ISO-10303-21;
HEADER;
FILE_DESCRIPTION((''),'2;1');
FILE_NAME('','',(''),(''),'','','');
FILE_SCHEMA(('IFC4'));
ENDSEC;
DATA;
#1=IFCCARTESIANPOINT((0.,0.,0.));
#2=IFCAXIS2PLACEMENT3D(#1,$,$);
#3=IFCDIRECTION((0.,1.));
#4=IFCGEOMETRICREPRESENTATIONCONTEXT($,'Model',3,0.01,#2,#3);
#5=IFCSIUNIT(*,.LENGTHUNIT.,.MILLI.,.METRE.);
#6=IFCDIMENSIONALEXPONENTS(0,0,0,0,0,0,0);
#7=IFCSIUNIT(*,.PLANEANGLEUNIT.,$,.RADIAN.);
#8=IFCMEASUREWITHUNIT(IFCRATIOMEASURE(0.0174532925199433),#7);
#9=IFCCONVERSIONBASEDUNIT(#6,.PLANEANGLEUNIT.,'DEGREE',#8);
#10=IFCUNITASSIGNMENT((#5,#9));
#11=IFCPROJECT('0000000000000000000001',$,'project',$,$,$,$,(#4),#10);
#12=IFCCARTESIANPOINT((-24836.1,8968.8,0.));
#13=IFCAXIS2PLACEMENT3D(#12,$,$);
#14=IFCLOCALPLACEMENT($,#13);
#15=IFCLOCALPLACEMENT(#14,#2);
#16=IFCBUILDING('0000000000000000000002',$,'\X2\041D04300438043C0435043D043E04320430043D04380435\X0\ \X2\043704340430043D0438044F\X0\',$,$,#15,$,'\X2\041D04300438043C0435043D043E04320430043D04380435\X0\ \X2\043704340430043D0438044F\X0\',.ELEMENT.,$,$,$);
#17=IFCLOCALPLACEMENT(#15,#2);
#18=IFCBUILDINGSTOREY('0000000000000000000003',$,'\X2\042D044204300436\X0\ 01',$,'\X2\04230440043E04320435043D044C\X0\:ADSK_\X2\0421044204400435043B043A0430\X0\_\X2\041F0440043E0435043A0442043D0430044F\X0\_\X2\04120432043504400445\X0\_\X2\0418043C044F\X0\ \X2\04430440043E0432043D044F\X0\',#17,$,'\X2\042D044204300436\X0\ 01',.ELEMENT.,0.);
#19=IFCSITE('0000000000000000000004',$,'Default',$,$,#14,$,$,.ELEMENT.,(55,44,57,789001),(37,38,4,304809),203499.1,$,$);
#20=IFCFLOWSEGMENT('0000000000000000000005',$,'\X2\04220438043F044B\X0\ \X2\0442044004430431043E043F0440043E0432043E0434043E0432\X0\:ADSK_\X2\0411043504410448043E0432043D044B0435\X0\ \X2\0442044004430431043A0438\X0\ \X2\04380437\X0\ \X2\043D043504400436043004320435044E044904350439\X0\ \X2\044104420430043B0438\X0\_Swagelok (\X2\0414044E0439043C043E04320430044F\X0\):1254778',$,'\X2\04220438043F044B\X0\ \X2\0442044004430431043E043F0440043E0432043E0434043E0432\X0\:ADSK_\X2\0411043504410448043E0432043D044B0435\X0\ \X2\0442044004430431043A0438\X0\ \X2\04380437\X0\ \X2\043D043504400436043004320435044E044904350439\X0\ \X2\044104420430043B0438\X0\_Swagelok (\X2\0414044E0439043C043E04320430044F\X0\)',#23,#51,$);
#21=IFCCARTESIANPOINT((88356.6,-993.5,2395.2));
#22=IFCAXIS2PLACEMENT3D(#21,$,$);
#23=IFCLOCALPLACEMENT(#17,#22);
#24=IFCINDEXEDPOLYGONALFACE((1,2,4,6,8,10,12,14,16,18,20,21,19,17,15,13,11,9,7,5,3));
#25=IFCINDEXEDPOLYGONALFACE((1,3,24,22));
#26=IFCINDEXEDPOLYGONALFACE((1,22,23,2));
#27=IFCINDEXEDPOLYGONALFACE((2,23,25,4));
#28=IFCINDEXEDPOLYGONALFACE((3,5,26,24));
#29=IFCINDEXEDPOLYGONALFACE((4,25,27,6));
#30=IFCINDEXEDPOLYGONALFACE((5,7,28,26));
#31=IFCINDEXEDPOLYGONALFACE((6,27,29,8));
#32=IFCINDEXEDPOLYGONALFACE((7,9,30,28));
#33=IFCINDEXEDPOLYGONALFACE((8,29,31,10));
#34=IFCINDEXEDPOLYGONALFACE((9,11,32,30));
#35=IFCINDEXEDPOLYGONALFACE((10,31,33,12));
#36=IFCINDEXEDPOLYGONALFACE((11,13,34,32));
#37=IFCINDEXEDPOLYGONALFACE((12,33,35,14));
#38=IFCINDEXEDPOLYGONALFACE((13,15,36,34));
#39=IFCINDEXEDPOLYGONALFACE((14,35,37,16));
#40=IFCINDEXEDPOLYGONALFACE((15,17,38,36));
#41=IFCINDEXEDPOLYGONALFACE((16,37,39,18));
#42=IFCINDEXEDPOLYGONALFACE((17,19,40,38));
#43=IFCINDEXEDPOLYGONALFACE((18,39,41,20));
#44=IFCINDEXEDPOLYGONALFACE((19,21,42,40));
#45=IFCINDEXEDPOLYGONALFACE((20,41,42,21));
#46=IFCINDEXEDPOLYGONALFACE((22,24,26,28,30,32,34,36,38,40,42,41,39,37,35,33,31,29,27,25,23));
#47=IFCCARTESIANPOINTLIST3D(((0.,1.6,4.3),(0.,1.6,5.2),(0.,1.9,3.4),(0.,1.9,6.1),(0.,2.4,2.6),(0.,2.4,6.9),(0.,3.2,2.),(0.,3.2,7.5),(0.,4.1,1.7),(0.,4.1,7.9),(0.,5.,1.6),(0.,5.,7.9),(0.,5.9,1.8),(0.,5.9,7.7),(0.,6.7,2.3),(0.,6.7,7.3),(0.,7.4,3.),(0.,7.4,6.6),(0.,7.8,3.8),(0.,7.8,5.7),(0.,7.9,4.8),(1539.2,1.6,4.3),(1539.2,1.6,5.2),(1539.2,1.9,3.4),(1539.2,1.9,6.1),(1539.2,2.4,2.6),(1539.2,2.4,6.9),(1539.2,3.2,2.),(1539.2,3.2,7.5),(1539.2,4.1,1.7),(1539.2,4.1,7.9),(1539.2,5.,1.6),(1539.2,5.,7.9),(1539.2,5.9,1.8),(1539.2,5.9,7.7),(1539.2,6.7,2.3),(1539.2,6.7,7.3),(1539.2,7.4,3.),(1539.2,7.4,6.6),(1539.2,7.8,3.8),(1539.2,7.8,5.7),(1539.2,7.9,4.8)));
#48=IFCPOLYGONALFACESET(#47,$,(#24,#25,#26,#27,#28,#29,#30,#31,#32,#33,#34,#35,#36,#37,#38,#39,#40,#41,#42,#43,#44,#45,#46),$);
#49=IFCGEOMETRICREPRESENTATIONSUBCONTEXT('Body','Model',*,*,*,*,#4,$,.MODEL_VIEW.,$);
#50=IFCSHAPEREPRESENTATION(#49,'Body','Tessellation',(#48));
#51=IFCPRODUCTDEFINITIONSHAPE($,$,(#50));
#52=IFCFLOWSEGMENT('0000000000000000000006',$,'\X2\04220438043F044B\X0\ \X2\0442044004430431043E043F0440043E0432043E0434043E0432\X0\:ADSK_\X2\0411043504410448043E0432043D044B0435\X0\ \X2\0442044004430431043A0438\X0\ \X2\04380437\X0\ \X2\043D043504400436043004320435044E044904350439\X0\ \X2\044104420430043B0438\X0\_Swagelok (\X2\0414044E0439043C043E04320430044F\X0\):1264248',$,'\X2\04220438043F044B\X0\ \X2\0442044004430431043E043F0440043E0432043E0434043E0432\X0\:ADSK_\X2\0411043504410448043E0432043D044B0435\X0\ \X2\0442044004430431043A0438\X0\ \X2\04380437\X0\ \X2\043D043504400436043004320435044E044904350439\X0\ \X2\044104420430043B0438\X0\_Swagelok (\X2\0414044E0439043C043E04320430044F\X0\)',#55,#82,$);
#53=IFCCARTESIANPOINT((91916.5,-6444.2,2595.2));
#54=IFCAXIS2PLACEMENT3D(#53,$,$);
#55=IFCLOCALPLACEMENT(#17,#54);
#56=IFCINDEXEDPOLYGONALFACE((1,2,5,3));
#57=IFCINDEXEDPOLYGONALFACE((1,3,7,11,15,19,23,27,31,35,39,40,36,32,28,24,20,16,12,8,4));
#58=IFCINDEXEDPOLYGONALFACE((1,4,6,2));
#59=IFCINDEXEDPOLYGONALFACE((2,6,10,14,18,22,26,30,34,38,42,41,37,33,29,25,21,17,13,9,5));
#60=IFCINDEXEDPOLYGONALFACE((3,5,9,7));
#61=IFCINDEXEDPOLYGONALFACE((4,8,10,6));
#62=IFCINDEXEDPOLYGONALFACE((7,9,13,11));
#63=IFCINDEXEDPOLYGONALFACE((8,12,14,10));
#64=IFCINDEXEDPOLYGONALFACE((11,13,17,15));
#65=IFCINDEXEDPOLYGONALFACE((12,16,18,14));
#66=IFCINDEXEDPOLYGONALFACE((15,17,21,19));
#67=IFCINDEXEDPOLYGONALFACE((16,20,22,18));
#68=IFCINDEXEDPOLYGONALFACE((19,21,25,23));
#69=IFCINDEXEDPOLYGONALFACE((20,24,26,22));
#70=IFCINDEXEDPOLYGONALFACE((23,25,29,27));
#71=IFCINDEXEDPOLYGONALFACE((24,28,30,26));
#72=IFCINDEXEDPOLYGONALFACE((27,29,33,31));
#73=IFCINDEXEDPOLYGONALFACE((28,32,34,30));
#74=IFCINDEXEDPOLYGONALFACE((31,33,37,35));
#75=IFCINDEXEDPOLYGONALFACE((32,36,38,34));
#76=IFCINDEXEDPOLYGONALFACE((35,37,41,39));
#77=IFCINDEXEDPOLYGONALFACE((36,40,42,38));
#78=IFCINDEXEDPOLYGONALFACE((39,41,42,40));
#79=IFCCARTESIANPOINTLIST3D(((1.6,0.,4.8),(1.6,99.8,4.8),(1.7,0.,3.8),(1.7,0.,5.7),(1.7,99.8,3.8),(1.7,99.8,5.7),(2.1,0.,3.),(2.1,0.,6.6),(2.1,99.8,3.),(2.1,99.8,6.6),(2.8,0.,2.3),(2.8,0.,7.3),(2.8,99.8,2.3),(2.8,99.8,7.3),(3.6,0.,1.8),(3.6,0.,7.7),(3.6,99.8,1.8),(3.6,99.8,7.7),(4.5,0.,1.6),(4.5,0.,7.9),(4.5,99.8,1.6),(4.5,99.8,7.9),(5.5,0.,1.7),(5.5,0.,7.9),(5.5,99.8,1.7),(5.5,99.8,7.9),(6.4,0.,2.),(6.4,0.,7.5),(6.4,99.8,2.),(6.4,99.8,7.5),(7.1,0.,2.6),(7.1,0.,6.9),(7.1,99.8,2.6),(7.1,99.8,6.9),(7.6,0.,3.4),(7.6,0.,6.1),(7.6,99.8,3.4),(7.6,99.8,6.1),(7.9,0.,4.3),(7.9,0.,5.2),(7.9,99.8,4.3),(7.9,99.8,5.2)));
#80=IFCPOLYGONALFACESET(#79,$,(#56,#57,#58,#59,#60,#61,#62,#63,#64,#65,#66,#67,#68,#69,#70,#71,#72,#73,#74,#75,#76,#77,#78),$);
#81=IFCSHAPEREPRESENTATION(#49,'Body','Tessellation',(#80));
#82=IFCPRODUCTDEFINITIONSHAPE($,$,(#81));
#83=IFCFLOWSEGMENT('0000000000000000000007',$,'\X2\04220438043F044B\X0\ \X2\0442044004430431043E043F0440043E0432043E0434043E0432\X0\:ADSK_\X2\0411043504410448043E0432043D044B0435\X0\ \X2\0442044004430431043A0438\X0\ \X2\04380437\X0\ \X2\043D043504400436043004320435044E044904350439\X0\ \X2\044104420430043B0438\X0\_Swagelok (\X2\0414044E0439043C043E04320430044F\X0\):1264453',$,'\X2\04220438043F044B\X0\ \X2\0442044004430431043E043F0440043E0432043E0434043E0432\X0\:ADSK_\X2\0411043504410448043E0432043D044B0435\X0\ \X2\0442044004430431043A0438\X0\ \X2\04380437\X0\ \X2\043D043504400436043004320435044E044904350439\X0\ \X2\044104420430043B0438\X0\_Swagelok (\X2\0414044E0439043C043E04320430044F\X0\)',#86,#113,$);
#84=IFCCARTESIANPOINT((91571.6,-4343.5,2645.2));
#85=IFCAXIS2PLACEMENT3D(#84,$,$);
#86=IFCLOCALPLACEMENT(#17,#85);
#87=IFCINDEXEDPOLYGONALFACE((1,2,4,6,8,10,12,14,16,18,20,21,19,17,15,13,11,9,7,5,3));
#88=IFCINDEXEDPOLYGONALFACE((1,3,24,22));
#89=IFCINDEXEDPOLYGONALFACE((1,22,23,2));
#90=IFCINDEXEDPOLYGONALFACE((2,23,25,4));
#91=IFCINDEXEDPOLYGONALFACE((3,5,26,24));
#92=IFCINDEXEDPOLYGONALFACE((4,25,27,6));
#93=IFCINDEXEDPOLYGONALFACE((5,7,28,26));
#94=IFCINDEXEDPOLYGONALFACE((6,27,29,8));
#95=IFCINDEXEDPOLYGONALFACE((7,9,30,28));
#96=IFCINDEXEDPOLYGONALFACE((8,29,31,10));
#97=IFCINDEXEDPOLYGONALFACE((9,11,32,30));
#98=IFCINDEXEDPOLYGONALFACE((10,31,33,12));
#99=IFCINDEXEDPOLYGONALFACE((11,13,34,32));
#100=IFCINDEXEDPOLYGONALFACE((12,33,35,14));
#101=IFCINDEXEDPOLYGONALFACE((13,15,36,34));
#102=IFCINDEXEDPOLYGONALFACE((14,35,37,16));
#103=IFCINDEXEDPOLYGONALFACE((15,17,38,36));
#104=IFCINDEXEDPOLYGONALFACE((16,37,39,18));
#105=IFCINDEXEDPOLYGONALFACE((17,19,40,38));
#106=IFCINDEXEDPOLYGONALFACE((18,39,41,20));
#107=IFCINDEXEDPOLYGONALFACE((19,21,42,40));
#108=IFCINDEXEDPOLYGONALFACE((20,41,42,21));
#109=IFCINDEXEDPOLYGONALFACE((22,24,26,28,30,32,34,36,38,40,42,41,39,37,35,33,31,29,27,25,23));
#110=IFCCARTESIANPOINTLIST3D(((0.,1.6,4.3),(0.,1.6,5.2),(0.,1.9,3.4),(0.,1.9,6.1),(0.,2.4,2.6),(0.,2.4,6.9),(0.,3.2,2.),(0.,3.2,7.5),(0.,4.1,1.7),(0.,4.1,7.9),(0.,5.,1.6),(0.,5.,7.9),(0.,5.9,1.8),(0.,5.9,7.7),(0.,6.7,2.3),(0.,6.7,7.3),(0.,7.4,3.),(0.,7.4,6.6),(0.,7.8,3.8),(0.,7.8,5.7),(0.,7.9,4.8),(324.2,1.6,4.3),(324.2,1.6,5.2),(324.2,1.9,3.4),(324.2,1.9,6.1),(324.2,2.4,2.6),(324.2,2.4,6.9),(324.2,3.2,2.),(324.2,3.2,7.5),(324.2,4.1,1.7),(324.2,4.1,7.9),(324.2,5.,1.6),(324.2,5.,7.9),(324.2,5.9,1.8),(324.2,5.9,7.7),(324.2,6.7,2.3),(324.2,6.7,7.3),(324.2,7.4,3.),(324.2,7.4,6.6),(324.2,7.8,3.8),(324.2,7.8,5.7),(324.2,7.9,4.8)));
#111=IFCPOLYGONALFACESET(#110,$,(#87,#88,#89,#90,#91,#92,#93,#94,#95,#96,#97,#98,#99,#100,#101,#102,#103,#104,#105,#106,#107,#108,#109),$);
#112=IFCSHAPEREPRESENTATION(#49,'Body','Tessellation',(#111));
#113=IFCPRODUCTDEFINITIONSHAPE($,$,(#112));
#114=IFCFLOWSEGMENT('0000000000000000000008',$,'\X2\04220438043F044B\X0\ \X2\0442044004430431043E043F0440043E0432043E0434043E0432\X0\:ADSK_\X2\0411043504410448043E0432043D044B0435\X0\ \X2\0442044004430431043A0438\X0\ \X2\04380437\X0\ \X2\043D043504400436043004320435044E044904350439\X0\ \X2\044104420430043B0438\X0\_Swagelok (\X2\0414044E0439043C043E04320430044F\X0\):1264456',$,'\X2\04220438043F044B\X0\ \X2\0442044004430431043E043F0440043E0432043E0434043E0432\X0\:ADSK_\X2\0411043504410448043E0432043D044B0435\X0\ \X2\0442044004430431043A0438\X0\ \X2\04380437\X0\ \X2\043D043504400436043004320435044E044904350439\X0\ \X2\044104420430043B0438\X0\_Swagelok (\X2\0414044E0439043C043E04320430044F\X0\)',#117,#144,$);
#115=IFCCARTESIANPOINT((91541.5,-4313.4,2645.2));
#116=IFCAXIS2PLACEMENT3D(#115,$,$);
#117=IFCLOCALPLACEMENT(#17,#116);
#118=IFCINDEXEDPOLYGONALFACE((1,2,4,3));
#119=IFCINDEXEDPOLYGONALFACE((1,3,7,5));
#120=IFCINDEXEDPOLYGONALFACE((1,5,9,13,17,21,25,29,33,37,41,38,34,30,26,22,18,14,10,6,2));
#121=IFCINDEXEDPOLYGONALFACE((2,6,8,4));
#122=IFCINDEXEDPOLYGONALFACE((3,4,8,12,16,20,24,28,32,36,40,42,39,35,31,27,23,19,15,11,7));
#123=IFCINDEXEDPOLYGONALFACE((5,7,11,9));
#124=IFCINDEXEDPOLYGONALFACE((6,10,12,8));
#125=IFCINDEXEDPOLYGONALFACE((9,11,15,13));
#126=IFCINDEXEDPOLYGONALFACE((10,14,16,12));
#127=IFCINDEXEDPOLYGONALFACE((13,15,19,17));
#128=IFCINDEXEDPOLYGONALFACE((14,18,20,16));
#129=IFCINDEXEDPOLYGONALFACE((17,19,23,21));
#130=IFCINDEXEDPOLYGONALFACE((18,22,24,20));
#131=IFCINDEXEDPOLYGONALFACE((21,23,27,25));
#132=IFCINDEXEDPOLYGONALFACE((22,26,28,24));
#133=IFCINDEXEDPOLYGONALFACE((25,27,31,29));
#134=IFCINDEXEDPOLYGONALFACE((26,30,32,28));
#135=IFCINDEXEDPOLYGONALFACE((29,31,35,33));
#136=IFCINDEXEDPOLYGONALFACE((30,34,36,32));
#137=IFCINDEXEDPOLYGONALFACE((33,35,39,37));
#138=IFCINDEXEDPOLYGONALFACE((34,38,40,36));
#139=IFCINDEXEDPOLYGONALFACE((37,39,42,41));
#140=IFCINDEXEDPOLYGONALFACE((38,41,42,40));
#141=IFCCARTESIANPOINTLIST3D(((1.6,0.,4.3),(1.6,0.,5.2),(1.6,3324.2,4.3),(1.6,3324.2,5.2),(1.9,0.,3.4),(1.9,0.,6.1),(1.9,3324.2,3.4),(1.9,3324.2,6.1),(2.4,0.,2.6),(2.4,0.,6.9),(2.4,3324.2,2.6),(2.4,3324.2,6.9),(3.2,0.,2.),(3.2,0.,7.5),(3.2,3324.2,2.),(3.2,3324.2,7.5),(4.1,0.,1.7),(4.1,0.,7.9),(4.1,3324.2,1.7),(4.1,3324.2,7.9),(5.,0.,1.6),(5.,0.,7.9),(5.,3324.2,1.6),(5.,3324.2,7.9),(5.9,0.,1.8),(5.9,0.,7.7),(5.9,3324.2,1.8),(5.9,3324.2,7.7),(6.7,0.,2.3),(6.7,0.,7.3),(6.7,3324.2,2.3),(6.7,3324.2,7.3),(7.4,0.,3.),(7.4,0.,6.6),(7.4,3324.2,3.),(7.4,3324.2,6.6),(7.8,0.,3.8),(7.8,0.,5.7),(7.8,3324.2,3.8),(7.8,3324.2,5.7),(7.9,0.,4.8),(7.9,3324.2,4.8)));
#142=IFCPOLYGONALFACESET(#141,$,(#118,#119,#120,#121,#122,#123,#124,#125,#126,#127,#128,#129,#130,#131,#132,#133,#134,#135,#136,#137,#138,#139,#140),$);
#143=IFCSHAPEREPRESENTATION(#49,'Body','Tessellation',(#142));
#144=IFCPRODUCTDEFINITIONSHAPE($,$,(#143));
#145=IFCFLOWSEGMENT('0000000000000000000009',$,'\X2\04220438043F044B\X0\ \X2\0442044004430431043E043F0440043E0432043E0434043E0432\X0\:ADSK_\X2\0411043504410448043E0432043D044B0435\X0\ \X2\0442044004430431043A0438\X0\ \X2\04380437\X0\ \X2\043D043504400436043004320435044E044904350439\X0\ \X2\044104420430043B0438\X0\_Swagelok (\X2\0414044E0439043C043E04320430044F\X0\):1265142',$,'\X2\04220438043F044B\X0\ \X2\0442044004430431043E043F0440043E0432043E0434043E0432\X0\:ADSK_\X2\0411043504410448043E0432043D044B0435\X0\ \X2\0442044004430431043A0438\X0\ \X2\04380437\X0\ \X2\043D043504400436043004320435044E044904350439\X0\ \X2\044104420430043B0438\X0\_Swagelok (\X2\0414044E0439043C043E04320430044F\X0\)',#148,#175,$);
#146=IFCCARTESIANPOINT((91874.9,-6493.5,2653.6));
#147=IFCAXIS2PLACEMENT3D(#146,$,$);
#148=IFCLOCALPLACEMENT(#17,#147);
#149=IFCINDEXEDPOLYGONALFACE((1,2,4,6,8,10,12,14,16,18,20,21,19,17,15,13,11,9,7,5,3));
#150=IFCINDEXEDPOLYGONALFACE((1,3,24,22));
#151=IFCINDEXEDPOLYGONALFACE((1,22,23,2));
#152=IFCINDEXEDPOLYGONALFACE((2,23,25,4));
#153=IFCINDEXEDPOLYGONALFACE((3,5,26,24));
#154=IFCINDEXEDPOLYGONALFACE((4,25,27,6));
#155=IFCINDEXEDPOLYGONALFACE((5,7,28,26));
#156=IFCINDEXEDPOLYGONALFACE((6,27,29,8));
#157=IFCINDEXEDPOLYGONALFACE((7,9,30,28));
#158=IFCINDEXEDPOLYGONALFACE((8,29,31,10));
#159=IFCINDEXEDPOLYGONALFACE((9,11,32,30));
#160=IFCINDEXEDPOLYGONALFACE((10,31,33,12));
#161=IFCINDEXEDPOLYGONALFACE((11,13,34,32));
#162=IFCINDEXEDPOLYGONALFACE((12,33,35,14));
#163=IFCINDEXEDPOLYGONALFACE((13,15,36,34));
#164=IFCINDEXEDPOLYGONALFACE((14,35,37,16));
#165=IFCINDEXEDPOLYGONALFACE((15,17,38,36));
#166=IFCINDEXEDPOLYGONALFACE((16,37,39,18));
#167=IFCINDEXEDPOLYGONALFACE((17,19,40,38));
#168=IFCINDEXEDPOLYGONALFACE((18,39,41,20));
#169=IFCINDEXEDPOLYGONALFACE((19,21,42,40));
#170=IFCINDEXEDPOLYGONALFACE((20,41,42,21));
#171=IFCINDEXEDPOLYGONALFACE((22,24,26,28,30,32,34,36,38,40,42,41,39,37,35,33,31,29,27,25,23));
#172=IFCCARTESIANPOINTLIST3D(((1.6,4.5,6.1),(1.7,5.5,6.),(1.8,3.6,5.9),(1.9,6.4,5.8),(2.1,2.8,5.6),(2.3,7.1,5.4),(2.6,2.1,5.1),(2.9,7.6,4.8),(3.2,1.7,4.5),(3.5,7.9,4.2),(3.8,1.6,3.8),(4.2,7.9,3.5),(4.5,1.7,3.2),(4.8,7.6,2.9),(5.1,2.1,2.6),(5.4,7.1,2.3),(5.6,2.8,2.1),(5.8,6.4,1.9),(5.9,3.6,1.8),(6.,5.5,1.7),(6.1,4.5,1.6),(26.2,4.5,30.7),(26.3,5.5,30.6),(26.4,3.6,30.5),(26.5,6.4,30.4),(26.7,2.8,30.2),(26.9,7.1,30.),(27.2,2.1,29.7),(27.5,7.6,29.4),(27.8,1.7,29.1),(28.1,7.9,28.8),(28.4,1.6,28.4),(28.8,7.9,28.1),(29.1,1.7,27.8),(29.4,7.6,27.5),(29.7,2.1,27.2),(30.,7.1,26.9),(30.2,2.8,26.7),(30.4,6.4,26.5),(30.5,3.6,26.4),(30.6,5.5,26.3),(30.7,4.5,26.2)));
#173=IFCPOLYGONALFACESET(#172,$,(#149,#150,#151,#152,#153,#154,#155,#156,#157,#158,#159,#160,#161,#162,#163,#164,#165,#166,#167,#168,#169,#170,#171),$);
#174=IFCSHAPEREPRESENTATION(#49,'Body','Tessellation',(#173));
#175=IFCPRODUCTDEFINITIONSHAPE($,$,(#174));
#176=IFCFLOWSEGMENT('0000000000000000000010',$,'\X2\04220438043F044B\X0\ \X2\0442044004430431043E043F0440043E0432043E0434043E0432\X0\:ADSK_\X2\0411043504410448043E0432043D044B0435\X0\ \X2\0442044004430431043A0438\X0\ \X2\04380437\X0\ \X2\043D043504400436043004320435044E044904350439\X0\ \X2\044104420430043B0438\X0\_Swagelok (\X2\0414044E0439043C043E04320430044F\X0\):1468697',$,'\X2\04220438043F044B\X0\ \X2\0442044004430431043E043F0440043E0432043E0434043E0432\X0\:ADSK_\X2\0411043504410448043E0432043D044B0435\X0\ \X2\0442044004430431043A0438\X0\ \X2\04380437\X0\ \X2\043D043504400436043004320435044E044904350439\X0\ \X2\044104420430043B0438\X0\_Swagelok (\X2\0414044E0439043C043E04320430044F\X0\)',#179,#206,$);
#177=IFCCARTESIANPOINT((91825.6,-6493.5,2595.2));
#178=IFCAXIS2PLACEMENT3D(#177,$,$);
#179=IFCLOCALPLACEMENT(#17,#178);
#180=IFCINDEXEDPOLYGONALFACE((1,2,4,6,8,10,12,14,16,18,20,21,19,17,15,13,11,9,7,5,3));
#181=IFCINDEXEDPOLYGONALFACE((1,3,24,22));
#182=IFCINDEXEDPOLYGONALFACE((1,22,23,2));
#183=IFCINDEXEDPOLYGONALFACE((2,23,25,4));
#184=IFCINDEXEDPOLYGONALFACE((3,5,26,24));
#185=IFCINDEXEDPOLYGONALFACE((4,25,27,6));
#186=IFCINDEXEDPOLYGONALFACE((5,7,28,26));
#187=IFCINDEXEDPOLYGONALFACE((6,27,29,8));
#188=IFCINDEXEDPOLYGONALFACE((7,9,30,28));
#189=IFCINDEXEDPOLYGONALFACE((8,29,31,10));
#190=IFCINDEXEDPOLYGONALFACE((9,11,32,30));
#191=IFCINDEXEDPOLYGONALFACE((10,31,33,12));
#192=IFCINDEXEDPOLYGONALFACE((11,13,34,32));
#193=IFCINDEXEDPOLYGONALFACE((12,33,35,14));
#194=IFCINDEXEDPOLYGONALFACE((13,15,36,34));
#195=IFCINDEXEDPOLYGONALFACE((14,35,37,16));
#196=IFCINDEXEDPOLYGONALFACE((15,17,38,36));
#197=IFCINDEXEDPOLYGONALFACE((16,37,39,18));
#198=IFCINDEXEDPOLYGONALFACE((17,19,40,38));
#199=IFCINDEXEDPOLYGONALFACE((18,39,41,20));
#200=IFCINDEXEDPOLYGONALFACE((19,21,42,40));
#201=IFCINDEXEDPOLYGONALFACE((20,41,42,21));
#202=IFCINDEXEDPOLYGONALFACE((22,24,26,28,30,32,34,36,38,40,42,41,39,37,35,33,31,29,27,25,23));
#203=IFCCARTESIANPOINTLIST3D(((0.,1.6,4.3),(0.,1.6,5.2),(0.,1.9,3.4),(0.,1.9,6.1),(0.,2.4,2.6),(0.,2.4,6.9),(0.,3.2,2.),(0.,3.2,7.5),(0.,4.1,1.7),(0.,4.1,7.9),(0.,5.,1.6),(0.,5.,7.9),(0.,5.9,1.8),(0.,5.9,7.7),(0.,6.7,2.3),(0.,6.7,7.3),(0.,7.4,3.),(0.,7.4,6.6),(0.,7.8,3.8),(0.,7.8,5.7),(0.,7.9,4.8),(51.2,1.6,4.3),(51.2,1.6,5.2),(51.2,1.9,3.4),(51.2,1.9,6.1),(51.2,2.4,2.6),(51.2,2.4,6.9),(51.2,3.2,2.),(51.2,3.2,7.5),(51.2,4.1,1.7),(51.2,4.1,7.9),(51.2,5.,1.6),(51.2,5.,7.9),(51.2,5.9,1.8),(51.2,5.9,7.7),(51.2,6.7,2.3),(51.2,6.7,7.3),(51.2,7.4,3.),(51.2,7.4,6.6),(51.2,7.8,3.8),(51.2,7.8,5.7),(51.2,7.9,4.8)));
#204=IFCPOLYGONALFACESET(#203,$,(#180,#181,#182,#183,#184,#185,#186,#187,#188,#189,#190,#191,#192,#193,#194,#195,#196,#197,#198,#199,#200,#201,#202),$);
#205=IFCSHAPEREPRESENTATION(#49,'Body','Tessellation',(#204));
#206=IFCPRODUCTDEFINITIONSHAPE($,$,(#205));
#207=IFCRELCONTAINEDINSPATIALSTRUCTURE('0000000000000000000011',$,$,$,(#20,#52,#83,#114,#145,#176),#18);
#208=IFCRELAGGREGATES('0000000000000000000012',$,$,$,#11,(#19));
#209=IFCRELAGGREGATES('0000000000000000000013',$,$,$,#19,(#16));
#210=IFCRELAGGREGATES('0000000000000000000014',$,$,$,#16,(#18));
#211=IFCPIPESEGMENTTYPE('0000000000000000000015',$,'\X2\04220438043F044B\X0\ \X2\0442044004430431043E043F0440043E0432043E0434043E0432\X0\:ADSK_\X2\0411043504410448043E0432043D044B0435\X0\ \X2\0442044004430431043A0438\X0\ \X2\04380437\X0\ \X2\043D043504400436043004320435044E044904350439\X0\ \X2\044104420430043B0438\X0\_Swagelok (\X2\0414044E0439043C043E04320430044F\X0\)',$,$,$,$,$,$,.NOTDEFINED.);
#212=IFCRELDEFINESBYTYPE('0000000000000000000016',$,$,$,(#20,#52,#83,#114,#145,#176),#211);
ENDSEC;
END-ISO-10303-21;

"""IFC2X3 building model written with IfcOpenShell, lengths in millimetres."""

from ifc_helpers import new_model, entity, si_unit, converted_unit, direction, frame, origin, origin_2d_with_axis, place, context, subcontext, project, spatial, circle, extrude, type_object, element, save


model = new_model("IFC2X3")

# Units and contexts
model_context = context("Model", 3, precision=0.01, world=origin(), true_north=direction((0.0, 1.0)))
body_context = subcontext(model_context, "Body", "Model", "MODEL_VIEW")
ifc_project = project(units=[si_unit("LENGTHUNIT", "METRE", prefix="MILLI"), converted_unit("PLANEANGLEUNIT", "DEGREE", entity("IfcRatioMeasure", 0.0174532925199433), si_unit("PLANEANGLEUNIT", "RADIAN"), dimensions=[0, 0, 0, 0, 0, 0, 0])], contexts=[model_context])

# Site, building, storey
site_placement = place(None, frame((-24836.1, 8968.8, 0.0)))
site = spatial("IfcSite", under=ifc_project, at=site_placement, Name="Default", CompositionType="ELEMENT", RefLatitude=(55, 44, 57, 789001), RefLongitude=(37, 38, 4, 304809), RefElevation=203499.1)
building_placement = place(site_placement, origin())
building = spatial("IfcBuilding", under=site, at=building_placement, Name="Наименование здания", LongName="Наименование здания", CompositionType="ELEMENT")
storey_placement = place(building_placement, origin())
storey = spatial("IfcBuildingStorey", under=building, at=storey_placement, Name="Этаж 01", ObjectType="Уровень:ADSK_Стрелка_Проектная_Вверх_Имя уровня", LongName="Этаж 01", CompositionType="ELEMENT", Elevation=0.0)

# Flow segments
pipe_segment_type_1 = type_object("IfcPipeSegmentType", Name="Типы трубопроводов:ADSK_Бесшовные трубки из нержавеющей стали_Swagelok (Дюймовая)", PredefinedType="NOTDEFINED")
flow_segment_1_placement = place(storey_placement, frame((88356.6, -993.5, 2395.2)))
element("IfcFlowSegment", 1, at=flow_segment_1_placement, inside=storey, type_object=pipe_segment_type_1, Name="Типы трубопроводов:ADSK_Бесшовные трубки из нержавеющей стали_Swagelok (Дюймовая):1254778", ObjectType="Типы трубопроводов:ADSK_Бесшовные трубки из нержавеющей стали_Swagelok (Дюймовая)", context=body_context, shape_type="SweptSolid", body=[
    extrude(circle(Radius=3.2, at=origin_2d_with_axis()), frame((0.0, 4.8, 4.8), z_axis=(1.0, 0.0, 0.0), x_axis=(0.0, 1.0, 0.0)), (0.0, 0.0, 1.0), 1539.2),
])
flow_segment_2_placement = place(storey_placement, frame((91916.5, -6444.2, 2595.2)))
element("IfcFlowSegment", 2, at=flow_segment_2_placement, inside=storey, type_object=pipe_segment_type_1, Name="Типы трубопроводов:ADSK_Бесшовные трубки из нержавеющей стали_Swagelok (Дюймовая):1264248", ObjectType="Типы трубопроводов:ADSK_Бесшовные трубки из нержавеющей стали_Swagelok (Дюймовая)", context=body_context, shape_type="SweptSolid", body=[
    extrude(circle(Radius=3.2, at=origin_2d_with_axis()), frame((4.8, 0.0, 4.8), z_axis=(0.0, 1.0, 0.0), x_axis=(-1.0, 0.0, 0.0)), (0.0, 0.0, 1.0), 99.8),
])
flow_segment_3_placement = place(storey_placement, frame((91571.6, -4343.5, 2645.2)))
element("IfcFlowSegment", 3, at=flow_segment_3_placement, inside=storey, type_object=pipe_segment_type_1, Name="Типы трубопроводов:ADSK_Бесшовные трубки из нержавеющей стали_Swagelok (Дюймовая):1264453", ObjectType="Типы трубопроводов:ADSK_Бесшовные трубки из нержавеющей стали_Swagelok (Дюймовая)", context=body_context, shape_type="SweptSolid", body=[
    extrude(circle(Radius=3.2, at=origin_2d_with_axis()), frame((0.0, 4.8, 4.8), z_axis=(1.0, 0.0, 0.0), x_axis=(0.0, 1.0, 0.0)), (0.0, 0.0, 1.0), 324.2),
])
flow_segment_4_placement = place(storey_placement, frame((91541.5, -4313.4, 2645.2)))
element("IfcFlowSegment", 4, at=flow_segment_4_placement, inside=storey, type_object=pipe_segment_type_1, Name="Типы трубопроводов:ADSK_Бесшовные трубки из нержавеющей стали_Swagelok (Дюймовая):1264456", ObjectType="Типы трубопроводов:ADSK_Бесшовные трубки из нержавеющей стали_Swagelok (Дюймовая)", context=body_context, shape_type="SweptSolid", body=[
    extrude(circle(Radius=3.2, at=origin_2d_with_axis()), frame((4.8, 0.0, 4.8), z_axis=(0.0, 1.0, 0.0), x_axis=(1.0, 0.0, 0.0)), (0.0, 0.0, 1.0), 3324.2),
])
flow_segment_5_placement = place(storey_placement, frame((91874.9, -6493.5, 2653.6)))
element("IfcFlowSegment", 5, at=flow_segment_5_placement, inside=storey, type_object=pipe_segment_type_1, Name="Типы трубопроводов:ADSK_Бесшовные трубки из нержавеющей стали_Swagelok (Дюймовая):1265142", ObjectType="Типы трубопроводов:ADSK_Бесшовные трубки из нержавеющей стали_Swagelok (Дюймовая)", context=body_context, shape_type="SweptSolid", body=[
    extrude(circle(Radius=3.2, at=origin_2d_with_axis()), frame((3.8, 4.8, 3.8), z_axis=(0.707107, 0.0, 0.707107), x_axis=(0.0, -1.0, 0.0)), (0.0, 0.0, 1.0), 34.8),
])
flow_segment_6_placement = place(storey_placement, frame((91825.6, -6493.5, 2595.2)))
element("IfcFlowSegment", 6, at=flow_segment_6_placement, inside=storey, type_object=pipe_segment_type_1, Name="Типы трубопроводов:ADSK_Бесшовные трубки из нержавеющей стали_Swagelok (Дюймовая):1468697", ObjectType="Типы трубопроводов:ADSK_Бесшовные трубки из нержавеющей стали_Swagelok (Дюймовая)", context=body_context, shape_type="SweptSolid", body=[
    extrude(circle(Radius=3.2, at=origin_2d_with_axis()), frame((0.0, 4.8, 4.8), z_axis=(1.0, 0.0, 0.0), x_axis=(0.0, 1.0, 0.0)), (0.0, 0.0, 1.0), 51.2),
])

save(model, "model.ifc")
